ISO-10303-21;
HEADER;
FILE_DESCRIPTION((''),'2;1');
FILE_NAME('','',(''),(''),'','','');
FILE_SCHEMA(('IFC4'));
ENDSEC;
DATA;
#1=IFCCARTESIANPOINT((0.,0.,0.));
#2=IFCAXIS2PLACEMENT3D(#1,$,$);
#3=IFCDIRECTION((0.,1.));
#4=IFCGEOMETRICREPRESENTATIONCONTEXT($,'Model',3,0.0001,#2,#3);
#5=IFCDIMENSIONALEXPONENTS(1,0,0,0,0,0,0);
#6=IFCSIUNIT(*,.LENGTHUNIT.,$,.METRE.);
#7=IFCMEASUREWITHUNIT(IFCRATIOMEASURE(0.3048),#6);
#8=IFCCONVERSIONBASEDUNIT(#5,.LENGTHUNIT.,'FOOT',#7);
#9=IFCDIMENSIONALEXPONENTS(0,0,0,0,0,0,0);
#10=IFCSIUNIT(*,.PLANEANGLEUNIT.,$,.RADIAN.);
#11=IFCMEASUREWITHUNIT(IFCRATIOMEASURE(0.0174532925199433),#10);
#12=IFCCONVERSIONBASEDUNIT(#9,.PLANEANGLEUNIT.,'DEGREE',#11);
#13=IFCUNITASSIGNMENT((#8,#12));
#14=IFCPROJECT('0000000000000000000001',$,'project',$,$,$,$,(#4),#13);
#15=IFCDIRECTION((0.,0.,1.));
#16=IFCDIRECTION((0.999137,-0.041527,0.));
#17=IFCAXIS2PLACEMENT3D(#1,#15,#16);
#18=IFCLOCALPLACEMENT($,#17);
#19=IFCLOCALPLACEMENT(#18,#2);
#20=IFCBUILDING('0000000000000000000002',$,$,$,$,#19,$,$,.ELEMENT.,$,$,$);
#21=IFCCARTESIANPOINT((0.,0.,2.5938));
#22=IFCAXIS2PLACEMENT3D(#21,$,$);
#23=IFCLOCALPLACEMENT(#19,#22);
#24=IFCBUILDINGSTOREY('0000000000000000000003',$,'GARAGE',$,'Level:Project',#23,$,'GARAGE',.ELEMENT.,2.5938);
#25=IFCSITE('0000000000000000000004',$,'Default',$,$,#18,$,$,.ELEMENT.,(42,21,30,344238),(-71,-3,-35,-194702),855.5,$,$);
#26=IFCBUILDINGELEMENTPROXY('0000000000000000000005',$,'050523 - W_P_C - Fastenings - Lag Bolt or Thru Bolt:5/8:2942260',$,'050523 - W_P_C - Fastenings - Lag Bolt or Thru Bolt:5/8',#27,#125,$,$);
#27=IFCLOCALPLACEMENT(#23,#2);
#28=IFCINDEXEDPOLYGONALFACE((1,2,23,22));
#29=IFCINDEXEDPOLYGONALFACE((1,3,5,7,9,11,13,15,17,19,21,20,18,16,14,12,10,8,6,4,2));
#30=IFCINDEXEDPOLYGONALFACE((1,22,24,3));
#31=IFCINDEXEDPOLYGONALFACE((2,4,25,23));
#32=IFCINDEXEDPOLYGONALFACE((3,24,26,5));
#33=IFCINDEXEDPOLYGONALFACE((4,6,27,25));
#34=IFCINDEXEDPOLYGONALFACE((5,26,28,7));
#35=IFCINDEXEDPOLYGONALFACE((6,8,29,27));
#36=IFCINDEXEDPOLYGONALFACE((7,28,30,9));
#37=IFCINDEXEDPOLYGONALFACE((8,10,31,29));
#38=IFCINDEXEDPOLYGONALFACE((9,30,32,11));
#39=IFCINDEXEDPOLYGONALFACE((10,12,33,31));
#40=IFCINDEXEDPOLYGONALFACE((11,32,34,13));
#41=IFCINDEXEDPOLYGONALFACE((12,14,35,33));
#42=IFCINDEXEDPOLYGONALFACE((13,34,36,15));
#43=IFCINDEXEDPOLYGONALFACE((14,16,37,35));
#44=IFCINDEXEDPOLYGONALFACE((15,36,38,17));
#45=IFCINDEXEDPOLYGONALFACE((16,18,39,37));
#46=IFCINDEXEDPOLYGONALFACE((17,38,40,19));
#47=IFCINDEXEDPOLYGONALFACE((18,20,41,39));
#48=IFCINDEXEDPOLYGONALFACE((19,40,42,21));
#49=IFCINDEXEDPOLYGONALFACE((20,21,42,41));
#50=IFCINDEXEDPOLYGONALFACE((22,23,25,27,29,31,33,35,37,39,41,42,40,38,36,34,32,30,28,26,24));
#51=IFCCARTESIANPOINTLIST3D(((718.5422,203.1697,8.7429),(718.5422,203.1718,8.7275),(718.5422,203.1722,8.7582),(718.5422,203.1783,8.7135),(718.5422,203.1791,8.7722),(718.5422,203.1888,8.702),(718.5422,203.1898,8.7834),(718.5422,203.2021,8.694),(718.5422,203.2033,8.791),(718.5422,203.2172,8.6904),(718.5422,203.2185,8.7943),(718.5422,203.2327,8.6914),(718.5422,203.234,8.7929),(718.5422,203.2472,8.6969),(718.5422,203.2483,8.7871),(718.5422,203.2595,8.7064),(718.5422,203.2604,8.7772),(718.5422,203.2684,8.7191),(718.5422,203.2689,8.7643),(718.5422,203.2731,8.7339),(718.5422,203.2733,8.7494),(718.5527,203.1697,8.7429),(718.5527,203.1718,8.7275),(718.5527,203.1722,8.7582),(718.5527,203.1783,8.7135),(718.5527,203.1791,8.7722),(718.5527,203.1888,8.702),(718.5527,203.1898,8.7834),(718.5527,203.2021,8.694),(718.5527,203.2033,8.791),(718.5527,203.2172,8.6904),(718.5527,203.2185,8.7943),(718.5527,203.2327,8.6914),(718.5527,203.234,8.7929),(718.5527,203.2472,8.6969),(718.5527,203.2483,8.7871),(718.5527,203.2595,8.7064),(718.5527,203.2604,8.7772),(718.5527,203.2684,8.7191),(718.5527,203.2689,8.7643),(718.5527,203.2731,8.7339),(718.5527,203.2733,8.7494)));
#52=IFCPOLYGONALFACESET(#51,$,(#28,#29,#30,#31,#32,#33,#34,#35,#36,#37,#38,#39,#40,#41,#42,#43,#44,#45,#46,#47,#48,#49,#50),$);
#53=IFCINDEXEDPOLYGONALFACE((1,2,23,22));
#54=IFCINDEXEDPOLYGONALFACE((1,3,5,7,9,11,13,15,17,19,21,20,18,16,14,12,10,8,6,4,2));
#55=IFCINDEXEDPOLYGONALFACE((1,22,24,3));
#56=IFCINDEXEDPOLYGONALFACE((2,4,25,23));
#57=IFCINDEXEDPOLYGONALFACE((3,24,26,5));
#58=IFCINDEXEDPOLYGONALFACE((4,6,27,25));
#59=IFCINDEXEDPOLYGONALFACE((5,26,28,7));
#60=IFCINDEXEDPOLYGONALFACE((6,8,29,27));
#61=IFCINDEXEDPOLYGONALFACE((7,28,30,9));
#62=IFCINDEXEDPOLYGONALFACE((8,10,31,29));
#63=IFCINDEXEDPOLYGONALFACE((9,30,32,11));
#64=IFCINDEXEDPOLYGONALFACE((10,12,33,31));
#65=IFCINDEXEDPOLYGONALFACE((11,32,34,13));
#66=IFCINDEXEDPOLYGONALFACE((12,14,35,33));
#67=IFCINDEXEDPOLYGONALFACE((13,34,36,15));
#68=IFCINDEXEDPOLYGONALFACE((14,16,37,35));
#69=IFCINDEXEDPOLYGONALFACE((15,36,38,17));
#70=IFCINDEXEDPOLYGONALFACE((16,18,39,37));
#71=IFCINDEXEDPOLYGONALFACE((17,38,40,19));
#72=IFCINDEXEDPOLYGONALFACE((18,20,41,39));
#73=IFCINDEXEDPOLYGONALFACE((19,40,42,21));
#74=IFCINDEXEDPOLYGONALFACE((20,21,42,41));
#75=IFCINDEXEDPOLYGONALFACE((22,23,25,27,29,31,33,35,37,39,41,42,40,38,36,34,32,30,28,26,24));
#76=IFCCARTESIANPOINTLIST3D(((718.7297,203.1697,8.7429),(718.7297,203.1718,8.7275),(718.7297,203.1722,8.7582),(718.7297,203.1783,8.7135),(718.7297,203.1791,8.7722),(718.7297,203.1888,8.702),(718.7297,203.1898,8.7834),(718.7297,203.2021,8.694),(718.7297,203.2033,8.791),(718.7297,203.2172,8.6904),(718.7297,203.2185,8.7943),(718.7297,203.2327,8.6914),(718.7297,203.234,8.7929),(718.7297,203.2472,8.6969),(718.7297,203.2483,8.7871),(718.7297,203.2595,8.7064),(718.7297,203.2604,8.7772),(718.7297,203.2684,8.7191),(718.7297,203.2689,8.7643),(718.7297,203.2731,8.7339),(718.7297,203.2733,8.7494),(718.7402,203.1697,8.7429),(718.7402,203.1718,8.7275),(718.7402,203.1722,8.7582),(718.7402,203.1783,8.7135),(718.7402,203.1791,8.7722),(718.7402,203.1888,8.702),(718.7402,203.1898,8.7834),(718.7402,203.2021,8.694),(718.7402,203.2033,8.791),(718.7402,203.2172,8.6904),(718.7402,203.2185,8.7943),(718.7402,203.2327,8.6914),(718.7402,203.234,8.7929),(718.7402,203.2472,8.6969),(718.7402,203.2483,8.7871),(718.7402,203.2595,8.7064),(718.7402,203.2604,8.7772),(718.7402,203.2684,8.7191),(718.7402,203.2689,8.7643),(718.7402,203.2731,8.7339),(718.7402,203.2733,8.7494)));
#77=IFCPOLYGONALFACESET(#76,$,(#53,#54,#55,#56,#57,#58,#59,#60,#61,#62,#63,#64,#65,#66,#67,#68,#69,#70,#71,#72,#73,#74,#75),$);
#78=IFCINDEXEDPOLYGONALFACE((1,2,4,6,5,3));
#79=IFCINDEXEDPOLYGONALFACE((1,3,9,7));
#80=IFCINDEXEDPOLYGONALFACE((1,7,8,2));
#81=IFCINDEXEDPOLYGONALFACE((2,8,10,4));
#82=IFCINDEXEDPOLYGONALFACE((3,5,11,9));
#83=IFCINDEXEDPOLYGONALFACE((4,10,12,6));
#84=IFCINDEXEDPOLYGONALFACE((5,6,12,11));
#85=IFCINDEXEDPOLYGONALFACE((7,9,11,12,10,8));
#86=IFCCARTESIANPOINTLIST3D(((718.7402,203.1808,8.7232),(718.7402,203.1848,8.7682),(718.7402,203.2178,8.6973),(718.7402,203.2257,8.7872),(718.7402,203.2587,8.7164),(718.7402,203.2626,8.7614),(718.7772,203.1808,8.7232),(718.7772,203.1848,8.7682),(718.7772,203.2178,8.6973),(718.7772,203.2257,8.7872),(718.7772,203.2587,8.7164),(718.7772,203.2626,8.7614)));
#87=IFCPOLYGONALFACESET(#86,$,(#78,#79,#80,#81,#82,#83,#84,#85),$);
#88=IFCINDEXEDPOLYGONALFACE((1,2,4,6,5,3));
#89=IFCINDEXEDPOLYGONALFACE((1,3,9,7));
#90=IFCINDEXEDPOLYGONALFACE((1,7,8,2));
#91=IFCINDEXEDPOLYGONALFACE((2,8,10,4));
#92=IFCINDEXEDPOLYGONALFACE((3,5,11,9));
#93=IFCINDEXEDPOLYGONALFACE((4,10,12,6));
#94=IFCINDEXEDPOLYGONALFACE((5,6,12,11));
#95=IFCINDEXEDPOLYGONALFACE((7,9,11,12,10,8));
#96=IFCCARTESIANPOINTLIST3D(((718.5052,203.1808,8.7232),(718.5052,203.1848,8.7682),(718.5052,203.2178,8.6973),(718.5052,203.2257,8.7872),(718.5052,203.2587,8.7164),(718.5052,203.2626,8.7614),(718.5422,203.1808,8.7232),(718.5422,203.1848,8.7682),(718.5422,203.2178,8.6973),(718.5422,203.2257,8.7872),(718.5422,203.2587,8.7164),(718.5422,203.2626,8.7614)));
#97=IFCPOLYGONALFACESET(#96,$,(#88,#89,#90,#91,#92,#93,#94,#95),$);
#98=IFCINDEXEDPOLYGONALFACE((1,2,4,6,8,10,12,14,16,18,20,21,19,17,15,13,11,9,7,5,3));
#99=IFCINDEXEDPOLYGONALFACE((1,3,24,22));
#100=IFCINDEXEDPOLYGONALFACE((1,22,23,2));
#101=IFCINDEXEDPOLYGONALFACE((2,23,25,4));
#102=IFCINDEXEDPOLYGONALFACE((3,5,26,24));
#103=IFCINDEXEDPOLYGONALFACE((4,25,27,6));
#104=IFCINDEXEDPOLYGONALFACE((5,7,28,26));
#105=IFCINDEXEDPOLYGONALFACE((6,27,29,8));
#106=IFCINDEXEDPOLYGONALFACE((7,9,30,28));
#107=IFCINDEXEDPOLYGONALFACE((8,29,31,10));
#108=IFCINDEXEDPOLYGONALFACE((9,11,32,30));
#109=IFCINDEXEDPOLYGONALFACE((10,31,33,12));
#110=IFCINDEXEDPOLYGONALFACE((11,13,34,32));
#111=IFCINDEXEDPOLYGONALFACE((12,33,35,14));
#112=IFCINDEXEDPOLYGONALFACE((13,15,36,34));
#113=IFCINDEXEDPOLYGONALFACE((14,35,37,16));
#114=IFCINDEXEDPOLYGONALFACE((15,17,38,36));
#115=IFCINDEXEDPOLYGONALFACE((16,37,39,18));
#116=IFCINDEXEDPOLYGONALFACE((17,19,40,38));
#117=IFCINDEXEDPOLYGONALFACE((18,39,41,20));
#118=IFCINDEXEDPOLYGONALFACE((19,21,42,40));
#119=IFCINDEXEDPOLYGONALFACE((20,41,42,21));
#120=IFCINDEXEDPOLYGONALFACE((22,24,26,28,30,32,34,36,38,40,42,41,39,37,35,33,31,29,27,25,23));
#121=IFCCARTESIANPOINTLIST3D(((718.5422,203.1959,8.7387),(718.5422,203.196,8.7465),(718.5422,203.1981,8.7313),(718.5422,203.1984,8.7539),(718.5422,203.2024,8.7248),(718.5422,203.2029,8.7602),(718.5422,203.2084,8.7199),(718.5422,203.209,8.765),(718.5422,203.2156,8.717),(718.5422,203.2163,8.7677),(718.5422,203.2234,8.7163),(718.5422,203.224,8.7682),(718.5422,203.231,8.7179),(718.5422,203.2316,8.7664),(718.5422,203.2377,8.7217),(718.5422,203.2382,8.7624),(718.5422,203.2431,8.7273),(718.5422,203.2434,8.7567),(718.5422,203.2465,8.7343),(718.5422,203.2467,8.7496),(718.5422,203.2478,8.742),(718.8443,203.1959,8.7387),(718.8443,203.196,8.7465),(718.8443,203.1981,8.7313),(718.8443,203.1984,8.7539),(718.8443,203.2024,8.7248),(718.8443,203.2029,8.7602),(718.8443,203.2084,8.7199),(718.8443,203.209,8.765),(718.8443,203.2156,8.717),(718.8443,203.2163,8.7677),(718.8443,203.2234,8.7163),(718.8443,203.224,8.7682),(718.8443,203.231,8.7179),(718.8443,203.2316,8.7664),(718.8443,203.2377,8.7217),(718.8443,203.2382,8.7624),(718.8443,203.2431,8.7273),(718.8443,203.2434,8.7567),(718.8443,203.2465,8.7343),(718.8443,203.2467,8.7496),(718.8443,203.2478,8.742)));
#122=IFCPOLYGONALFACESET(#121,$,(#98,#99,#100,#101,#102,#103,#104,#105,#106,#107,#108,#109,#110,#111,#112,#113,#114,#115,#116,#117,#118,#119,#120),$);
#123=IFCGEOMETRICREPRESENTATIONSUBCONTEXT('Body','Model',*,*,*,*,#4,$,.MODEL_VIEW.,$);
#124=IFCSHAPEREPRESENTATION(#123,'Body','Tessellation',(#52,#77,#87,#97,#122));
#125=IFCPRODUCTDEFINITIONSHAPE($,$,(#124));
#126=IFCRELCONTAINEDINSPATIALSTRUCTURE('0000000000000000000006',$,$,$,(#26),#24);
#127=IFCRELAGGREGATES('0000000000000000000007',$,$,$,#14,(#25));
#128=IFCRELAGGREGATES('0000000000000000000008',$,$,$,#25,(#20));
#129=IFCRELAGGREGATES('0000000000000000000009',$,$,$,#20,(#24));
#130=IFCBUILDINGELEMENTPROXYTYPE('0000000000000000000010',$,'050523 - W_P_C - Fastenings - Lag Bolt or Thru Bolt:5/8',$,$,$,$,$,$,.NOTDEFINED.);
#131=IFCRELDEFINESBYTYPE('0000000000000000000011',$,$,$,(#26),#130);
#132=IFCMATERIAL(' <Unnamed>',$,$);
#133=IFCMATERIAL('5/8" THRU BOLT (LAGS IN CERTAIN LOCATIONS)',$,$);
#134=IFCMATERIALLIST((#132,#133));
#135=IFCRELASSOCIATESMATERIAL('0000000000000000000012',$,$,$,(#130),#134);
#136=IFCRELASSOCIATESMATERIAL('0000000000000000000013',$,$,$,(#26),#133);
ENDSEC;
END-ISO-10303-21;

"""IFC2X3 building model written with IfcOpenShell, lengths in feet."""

from ifc_helpers import new_model, entity, si_unit, converted_unit, direction, frame, frame_2d, origin, place, context, subcontext, project, spatial, polyline, circle, outline, extrude, source, transform, mapped, material, material_list, type_object, type_shapes, element, save


model = new_model("IFC2X3")

# Units and contexts
model_context = context("Model", 3, precision=0.0001, world=origin(), true_north=direction((0.0, 1.0)))
body_context = subcontext(model_context, "Body", "Model", "MODEL_VIEW")
ifc_project = project(units=[converted_unit("LENGTHUNIT", "FOOT", entity("IfcRatioMeasure", 0.3048), si_unit("LENGTHUNIT", "METRE"), dimensions=[1, 0, 0, 0, 0, 0, 0]), converted_unit("PLANEANGLEUNIT", "DEGREE", entity("IfcRatioMeasure", 0.0174532925199433), si_unit("PLANEANGLEUNIT", "RADIAN"), dimensions=[0, 0, 0, 0, 0, 0, 0])], contexts=[model_context])

# Site, building, storey
site_placement = place(None, frame((0.0, 0.0, 0.0), z_axis=(0.0, 0.0, 1.0), x_axis=(0.999137, -0.041527, 0.0)))
site = spatial("IfcSite", under=ifc_project, at=site_placement, Name="Default", CompositionType="ELEMENT", RefLatitude=(42, 21, 30, 344238), RefLongitude=(-71, -3, -35, -194702), RefElevation=855.5)
building_placement = place(site_placement, origin())
building = spatial("IfcBuilding", under=site, at=building_placement, CompositionType="ELEMENT")
storey_placement = place(building_placement, frame((0.0, 0.0, 2.5938)))
storey = spatial("IfcBuildingStorey", under=building, at=storey_placement, Name="GARAGE", ObjectType="Level:Project", LongName="GARAGE", CompositionType="ELEMENT", Elevation=2.5938)

# Building element proxy
ifc_material_1 = material(Name="5/8\" THRU BOLT (LAGS IN CERTAIN LOCATIONS)")
ifc_material_2 = material(Name=" <Unnamed>")
ifc_material_list_1 = material_list([ifc_material_2, ifc_material_1])
building_element_proxy_type_1 = type_object("IfcBuildingElementProxyType", Name="050523 - W_P_C - Fastenings - Lag Bolt or Thru Bolt:5/8", PredefinedType="NOTDEFINED", material=ifc_material_list_1)
shared_shape_1 = source(origin(), body_context, "Body", "SweptSolid", [
    extrude(circle(Radius=0.0521, at=frame_2d((0.0, 0.0), x_axis=(1.0, 0.0))), frame((0.0, 0.0, 0.0), z_axis=(0.0, 0.0, 1.0), x_axis=(0.0, 1.0, 0.0)), (0.0, 0.0, 1.0), 0.0104),
    extrude(circle(Radius=0.0521, at=frame_2d((0.0, 0.0), x_axis=(1.0, 0.0))), frame((0.0, 0.0, -0.1875), z_axis=(0.0, 0.0, 1.0), x_axis=(0.0, 1.0, 0.0)), (0.0, 0.0, 1.0), 0.0104),
    extrude(outline(polyline([(-0.0226, -0.0391), (0.0226, -0.0391), (0.0451, 0.0), (0.0226, 0.0391), (-0.0226, 0.0391), (-0.0451, 0.0), (-0.0226, -0.0391)])), frame((0.0, 0.0, -0.2245), z_axis=(0.0, 0.0, 1.0), x_axis=(0.0, -1.0, 0.0)), (0.0, 0.0, 1.0), 0.037),
    extrude(outline(polyline([(-0.0226, -0.0391), (0.0226, -0.0391), (0.0451, 0.0), (0.0226, 0.0391), (-0.0226, 0.0391), (-0.0451, 0.0), (-0.0226, -0.0391)])), frame((0.0, 0.0, 0.0104), z_axis=(0.0, 0.0, 1.0), x_axis=(0.866025, -0.5, 0.0)), (0.0, 0.0, 1.0), 0.037),
    extrude(circle(Radius=0.026, at=frame_2d((0.0, 0.0), x_axis=(1.0, 0.0))), frame((0.0, 0.0, -0.2917), z_axis=(0.0, 0.0, 1.0), x_axis=(0.0, -1.0, 0.0)), (0.0, 0.0, 1.0), 0.3021),
])
type_shapes(building_element_proxy_type_1, [shared_shape_1])
for number, where, z_axis, x_axis, name in (
    (1, (718.5527, 203.2217, 8.7423), (-1.0, 0.0, 0.0), (0.0, 0.996195, -0.087156), "050523 - W_P_C - Fastenings - Lag Bolt or Thru Bolt:5/8:2942260"),
):
    element("IfcBuildingElementProxy", number, at=place(storey_placement, frame(where, z_axis=z_axis, x_axis=x_axis)), inside=storey, type_object=building_element_proxy_type_1, material=ifc_material_1, Name=name, ObjectType="050523 - W_P_C - Fastenings - Lag Bolt or Thru Bolt:5/8", context=body_context, shape_type="MappedRepresentation", body=[
        mapped(shared_shape_1, transform((0.0, 0.0, 0.0), scale=1.0)),
    ])

save(model, "model.ifc")
